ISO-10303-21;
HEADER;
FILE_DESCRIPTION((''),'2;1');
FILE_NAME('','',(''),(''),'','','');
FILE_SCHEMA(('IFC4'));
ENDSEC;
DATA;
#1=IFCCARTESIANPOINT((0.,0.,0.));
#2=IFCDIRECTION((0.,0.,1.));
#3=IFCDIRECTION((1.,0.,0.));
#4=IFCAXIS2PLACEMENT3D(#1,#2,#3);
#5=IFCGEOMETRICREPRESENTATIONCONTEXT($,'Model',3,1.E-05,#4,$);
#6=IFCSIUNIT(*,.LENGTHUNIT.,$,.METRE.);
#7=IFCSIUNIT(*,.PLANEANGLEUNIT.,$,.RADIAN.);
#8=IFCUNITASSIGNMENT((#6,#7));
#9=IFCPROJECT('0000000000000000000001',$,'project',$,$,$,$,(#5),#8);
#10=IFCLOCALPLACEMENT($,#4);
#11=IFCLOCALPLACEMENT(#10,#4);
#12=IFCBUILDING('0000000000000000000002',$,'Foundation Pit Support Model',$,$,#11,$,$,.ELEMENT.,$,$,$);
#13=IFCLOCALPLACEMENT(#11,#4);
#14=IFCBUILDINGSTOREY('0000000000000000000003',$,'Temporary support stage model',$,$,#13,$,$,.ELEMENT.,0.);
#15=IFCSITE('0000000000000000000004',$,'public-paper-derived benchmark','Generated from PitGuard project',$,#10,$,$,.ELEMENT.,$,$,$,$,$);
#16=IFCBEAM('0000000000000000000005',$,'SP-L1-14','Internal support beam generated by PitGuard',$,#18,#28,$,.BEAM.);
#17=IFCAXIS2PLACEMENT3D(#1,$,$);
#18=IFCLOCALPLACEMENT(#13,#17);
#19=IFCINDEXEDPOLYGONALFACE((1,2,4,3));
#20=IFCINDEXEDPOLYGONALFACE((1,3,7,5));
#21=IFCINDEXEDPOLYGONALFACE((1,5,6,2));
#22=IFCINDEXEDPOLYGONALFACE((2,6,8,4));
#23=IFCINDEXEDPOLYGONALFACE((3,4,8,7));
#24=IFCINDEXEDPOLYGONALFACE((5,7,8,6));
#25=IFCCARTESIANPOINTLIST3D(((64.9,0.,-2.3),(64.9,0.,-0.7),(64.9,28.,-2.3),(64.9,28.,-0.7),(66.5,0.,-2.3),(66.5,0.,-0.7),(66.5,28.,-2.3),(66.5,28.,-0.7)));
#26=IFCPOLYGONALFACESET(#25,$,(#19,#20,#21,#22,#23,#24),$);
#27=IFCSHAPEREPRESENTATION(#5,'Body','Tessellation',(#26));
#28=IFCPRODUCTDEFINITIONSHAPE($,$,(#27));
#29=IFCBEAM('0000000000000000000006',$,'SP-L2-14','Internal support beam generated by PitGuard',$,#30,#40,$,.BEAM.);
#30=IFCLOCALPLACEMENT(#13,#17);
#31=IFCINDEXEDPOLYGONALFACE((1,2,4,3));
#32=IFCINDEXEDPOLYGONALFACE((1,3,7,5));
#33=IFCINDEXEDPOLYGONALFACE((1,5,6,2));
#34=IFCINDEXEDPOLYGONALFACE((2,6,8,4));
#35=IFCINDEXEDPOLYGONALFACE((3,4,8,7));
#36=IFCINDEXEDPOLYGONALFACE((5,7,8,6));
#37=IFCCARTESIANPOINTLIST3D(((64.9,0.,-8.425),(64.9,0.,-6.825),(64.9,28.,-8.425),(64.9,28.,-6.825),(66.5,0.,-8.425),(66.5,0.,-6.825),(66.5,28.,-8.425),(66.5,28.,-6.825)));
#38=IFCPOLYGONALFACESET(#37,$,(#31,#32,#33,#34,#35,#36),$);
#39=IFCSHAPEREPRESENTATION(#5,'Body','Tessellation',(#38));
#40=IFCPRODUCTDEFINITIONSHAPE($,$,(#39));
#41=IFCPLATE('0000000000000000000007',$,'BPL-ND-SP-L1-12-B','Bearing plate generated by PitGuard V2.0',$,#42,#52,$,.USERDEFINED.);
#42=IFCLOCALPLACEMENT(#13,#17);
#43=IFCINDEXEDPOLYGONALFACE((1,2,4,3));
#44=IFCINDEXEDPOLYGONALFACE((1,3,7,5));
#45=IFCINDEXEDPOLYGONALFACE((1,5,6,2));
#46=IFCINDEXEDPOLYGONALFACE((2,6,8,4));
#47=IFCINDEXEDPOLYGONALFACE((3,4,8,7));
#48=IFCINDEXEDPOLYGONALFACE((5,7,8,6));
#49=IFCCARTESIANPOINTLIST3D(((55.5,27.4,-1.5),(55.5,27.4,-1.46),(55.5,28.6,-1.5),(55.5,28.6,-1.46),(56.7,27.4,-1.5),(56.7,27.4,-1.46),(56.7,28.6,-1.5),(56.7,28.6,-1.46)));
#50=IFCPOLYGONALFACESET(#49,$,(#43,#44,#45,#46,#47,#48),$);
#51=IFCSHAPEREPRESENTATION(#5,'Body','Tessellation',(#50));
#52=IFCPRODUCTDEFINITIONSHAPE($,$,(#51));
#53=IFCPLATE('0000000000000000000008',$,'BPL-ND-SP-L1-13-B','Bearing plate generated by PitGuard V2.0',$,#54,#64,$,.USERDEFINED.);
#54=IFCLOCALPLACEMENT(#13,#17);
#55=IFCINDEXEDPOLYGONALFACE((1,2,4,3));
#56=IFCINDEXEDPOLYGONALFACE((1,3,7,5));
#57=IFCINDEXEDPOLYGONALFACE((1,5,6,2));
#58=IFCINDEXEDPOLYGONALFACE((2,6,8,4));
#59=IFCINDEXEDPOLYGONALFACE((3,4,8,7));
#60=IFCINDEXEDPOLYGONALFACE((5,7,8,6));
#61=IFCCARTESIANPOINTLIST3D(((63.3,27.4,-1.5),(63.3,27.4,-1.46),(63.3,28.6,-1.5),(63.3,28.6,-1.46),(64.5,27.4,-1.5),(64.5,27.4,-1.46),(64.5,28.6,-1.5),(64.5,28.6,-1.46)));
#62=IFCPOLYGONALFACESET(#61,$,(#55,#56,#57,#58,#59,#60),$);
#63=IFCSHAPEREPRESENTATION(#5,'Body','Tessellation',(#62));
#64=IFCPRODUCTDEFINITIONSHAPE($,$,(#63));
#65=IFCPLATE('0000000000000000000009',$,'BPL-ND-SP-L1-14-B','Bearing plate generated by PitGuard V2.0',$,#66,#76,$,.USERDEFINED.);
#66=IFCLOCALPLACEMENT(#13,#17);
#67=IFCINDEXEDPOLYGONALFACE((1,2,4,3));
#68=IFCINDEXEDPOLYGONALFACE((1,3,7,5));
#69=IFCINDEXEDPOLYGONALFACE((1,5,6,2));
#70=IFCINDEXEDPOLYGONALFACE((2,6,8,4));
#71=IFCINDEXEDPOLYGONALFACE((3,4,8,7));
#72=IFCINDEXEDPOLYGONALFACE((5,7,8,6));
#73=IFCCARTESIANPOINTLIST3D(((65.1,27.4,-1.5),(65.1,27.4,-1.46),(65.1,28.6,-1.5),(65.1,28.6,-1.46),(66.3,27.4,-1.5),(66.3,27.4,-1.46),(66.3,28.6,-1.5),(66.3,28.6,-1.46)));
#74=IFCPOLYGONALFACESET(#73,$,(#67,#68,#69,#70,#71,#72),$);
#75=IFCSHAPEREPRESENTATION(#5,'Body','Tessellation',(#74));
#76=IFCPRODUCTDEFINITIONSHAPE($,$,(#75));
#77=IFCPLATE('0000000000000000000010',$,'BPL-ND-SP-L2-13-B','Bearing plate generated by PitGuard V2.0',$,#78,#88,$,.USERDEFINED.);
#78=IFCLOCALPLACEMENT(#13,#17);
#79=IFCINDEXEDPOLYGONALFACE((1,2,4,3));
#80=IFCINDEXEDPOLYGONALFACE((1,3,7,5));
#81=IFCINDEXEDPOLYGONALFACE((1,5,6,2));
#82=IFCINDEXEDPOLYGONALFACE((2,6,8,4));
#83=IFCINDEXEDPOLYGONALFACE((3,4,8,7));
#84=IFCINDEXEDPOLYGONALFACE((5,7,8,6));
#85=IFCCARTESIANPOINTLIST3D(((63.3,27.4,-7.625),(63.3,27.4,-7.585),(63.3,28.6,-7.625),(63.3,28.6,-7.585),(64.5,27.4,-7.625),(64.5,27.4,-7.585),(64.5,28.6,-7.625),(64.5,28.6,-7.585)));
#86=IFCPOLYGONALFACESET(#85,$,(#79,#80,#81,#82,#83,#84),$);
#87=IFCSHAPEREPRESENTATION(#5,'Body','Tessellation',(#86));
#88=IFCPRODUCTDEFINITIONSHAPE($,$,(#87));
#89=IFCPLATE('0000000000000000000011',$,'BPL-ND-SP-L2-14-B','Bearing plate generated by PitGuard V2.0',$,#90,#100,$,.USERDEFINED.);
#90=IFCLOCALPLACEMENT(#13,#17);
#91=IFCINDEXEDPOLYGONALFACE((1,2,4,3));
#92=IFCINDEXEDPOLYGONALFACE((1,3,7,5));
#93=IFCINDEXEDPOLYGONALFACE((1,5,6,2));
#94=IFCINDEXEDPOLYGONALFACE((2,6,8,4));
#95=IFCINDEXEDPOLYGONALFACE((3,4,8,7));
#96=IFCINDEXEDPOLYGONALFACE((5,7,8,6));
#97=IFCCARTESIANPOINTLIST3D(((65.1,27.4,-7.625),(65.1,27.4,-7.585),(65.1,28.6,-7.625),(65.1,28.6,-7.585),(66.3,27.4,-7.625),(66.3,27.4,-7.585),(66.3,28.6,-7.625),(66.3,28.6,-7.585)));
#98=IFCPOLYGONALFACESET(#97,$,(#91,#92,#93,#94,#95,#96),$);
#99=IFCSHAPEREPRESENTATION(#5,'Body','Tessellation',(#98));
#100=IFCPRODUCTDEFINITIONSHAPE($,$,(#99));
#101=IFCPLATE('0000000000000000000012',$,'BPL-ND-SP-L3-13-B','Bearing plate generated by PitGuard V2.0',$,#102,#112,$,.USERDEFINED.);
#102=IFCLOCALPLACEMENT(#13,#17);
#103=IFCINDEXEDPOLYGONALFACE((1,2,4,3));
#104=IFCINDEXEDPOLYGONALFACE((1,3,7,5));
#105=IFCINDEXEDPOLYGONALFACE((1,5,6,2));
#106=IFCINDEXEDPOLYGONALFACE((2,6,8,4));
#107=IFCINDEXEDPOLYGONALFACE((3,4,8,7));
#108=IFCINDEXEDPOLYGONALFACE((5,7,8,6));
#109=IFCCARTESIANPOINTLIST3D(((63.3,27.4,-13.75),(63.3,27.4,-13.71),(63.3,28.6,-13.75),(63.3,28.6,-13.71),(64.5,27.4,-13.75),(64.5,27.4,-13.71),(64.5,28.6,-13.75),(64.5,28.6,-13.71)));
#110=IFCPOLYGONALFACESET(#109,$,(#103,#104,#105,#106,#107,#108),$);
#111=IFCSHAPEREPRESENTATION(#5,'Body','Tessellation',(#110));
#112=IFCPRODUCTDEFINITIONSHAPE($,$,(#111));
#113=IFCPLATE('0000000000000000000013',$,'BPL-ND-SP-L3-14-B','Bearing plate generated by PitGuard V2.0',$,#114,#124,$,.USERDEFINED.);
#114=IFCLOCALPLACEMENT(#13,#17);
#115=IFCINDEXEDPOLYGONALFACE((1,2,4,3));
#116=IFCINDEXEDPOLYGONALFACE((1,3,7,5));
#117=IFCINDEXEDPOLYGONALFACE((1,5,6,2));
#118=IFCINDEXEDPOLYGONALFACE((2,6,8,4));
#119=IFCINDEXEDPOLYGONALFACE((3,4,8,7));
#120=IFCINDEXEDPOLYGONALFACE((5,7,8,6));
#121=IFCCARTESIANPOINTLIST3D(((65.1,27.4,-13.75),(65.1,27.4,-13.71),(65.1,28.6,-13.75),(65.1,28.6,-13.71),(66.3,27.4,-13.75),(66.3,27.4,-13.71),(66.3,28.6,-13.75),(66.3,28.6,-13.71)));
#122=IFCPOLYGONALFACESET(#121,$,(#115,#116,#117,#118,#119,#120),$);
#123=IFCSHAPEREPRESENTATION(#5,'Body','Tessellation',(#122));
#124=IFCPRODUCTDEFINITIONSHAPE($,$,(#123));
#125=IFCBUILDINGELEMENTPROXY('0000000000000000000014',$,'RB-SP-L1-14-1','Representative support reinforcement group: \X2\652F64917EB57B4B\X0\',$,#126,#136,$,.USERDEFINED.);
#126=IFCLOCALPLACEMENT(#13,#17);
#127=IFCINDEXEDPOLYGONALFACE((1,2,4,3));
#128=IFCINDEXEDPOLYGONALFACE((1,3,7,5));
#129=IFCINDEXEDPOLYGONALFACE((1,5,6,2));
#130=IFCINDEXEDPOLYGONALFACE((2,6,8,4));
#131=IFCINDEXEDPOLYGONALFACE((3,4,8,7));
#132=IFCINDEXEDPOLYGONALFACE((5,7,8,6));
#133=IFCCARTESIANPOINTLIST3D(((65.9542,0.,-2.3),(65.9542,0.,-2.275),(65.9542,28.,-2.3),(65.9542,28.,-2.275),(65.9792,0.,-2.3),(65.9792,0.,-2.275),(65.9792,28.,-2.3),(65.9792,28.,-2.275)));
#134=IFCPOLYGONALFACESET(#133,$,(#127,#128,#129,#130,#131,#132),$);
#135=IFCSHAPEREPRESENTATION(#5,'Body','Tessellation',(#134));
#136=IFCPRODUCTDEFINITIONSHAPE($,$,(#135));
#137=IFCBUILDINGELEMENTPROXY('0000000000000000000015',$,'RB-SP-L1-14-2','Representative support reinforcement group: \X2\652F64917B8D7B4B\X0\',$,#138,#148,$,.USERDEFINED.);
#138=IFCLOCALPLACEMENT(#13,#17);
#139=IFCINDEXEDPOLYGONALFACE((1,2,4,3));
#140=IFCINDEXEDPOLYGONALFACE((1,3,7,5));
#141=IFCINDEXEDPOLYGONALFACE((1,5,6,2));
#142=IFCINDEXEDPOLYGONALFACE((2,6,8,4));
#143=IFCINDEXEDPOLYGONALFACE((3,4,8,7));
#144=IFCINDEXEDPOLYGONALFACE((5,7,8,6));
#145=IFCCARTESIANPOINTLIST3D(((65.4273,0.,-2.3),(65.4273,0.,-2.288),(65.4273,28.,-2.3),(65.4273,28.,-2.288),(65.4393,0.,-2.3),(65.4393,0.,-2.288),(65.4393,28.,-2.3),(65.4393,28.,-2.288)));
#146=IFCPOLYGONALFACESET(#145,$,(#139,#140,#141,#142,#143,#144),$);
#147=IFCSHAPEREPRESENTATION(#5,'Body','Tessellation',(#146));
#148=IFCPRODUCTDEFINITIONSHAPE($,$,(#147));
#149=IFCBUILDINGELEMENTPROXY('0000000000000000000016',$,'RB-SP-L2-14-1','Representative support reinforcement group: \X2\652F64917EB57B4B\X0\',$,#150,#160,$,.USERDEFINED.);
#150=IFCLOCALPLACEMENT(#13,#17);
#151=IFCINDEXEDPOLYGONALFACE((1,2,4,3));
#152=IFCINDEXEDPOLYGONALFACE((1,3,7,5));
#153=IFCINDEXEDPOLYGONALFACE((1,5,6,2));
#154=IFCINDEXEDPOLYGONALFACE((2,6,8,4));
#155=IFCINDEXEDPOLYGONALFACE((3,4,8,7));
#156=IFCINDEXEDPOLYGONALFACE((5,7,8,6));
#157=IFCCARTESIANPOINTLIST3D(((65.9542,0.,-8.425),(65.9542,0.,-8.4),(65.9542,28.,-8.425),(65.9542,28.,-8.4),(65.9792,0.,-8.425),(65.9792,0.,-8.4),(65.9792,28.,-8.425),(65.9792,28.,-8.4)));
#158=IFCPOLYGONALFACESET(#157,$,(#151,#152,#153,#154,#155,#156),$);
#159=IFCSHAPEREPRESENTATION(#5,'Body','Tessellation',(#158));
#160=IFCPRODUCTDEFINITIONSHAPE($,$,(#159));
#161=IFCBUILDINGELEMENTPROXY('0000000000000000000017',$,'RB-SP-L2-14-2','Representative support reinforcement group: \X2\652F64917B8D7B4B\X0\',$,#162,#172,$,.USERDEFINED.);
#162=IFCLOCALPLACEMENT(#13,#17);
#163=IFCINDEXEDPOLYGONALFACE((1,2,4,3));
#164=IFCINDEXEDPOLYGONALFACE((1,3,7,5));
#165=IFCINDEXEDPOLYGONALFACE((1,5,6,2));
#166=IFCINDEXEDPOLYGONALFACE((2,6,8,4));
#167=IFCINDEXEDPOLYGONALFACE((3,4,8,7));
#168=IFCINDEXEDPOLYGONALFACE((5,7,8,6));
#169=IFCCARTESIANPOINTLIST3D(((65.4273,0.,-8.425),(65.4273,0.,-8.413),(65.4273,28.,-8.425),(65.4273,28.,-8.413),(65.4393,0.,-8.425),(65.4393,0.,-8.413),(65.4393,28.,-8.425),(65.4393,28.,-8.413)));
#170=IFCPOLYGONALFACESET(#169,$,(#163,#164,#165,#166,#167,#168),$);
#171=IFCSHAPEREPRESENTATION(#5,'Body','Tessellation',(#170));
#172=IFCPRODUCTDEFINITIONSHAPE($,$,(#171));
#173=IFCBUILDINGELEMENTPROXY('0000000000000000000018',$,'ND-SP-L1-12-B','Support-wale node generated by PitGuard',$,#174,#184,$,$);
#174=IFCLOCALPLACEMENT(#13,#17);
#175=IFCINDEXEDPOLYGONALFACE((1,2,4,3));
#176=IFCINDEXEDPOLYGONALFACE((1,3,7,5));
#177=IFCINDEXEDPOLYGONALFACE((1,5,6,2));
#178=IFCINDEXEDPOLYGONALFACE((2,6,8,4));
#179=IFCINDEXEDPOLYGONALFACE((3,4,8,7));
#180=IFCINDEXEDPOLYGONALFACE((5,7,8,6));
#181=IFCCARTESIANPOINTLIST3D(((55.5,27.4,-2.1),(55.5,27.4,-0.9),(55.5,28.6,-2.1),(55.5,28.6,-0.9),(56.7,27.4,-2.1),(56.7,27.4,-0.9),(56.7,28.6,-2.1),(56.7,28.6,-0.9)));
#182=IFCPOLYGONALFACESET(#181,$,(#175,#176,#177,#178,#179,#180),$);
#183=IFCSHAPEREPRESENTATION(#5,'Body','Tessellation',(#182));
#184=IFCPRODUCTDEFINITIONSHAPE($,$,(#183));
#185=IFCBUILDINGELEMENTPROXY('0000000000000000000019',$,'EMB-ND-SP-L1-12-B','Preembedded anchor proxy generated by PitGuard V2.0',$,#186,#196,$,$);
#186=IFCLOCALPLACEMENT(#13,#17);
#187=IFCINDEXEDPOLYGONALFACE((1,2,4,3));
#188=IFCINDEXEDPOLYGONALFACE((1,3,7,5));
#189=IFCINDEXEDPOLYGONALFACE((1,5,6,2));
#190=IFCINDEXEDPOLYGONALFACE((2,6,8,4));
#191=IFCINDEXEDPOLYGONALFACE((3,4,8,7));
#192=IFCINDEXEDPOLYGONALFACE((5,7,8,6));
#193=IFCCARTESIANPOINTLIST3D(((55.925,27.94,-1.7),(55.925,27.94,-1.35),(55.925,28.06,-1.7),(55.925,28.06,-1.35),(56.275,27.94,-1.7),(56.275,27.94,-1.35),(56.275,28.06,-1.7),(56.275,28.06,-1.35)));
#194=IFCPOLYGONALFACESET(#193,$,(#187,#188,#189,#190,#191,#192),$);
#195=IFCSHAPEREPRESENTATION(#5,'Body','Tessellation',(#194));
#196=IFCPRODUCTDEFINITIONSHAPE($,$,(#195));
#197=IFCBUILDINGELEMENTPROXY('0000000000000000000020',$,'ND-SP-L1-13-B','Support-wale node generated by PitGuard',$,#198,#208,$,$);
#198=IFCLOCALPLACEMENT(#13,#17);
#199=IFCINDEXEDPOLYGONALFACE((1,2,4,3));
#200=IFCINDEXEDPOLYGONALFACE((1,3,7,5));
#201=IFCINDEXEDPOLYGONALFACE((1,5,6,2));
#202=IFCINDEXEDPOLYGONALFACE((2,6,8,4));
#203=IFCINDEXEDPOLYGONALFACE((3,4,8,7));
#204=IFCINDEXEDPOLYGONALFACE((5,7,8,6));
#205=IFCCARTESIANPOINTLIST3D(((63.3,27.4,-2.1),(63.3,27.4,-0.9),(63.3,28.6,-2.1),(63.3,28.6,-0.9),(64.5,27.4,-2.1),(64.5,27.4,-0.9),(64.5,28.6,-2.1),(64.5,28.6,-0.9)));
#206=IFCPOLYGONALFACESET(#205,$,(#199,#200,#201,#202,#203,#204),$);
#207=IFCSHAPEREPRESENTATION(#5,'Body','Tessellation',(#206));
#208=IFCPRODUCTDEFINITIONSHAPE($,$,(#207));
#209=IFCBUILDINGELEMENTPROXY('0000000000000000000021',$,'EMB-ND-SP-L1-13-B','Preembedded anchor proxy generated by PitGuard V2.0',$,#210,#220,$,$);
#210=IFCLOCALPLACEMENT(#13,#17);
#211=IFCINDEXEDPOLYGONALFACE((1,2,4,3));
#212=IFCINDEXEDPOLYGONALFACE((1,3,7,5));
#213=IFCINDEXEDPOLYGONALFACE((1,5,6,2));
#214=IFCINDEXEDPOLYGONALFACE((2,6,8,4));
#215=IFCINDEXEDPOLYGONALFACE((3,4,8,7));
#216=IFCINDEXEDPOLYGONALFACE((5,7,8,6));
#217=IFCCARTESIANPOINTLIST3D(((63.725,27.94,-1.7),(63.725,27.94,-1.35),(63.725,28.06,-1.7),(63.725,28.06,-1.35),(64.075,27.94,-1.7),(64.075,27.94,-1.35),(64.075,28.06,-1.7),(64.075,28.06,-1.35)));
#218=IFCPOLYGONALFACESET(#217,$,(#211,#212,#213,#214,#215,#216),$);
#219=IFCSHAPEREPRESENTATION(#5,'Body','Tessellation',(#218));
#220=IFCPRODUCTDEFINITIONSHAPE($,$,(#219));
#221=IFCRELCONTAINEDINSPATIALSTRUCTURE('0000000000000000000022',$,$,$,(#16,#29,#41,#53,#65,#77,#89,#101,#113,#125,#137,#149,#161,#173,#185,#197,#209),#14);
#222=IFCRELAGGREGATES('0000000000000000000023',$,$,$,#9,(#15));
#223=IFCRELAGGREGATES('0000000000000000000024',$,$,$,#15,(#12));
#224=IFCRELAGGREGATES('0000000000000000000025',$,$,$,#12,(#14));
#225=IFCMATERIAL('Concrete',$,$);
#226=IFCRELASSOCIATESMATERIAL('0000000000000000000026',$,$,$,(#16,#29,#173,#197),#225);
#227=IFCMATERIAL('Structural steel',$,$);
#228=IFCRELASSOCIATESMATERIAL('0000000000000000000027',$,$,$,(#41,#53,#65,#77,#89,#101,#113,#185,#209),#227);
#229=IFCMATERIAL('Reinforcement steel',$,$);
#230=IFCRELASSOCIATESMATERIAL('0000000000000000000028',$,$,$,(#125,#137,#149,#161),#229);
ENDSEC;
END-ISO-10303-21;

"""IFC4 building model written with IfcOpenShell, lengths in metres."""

from ifc_helpers import new_model, si_unit, frame, origin_with_axes, origin_2d, place, context, project, spatial, rectangle, extrude, material, element, save


model = new_model("IFC4")

# Units and contexts
model_context = context("Model", 3, precision=1e-05, world=origin_with_axes())
ifc_project = project(units=[si_unit("LENGTHUNIT", "METRE"), si_unit("PLANEANGLEUNIT", "RADIAN")], contexts=[model_context])

# Site, building, storey
site_placement = place(None, origin_with_axes())
site = spatial("IfcSite", under=ifc_project, at=site_placement, Name="public-paper-derived benchmark", Description="Generated from PitGuard project", CompositionType="ELEMENT")
building_placement = place(site_placement, origin_with_axes())
building = spatial("IfcBuilding", under=site, at=building_placement, Name="Foundation Pit Support Model", CompositionType="ELEMENT")
storey_placement = place(building_placement, origin_with_axes())
storey = spatial("IfcBuildingStorey", under=building, at=storey_placement, Name="Temporary support stage model", CompositionType="ELEMENT", Elevation=0.0)

# Beams
ifc_material_1 = material(Name="Concrete")
for number, where, z_axis, x_axis, name in (
    (1, (65.7, 14.0, -2.3), (0.0, 0.0, 1.0), (0.0, 1.0, 0.0), "SP-L1-14"),
    (2, (65.7, 14.0, -8.425), (0.0, 0.0, 1.0), (0.0, 1.0, 0.0), "SP-L2-14"),
):
    element("IfcBeam", number, at=place(storey_placement, frame(where, z_axis=z_axis, x_axis=x_axis)), inside=storey, material=ifc_material_1, Name=name, Description="Internal support beam generated by PitGuard", PredefinedType="BEAM", context=model_context, shape_type="SweptSolid", body=[
        extrude(rectangle(XDim=28.0, YDim=1.6, at=origin_2d()), origin_with_axes(), (0.0, 0.0, 1.0), 1.6),
    ])

# Plates
ifc_material_2 = material(Name="Structural steel")
for number, where, z_axis, x_axis, name in (
    (3, (56.1, 28.0, -1.5), (0.0, 0.0, 1.0), (1.0, 0.0, 0.0), "BPL-ND-SP-L1-12-B"),
    (4, (63.9, 28.0, -1.5), (0.0, 0.0, 1.0), (1.0, 0.0, 0.0), "BPL-ND-SP-L1-13-B"),
    (5, (65.7, 28.0, -1.5), (0.0, 0.0, 1.0), (1.0, 0.0, 0.0), "BPL-ND-SP-L1-14-B"),
    (6, (63.9, 28.0, -7.625), (0.0, 0.0, 1.0), (1.0, 0.0, 0.0), "BPL-ND-SP-L2-13-B"),
    (7, (65.7, 28.0, -7.625), (0.0, 0.0, 1.0), (1.0, 0.0, 0.0), "BPL-ND-SP-L2-14-B"),
    (8, (63.9, 28.0, -13.75), (0.0, 0.0, 1.0), (1.0, 0.0, 0.0), "BPL-ND-SP-L3-13-B"),
    (9, (65.7, 28.0, -13.75), (0.0, 0.0, 1.0), (1.0, 0.0, 0.0), "BPL-ND-SP-L3-14-B"),
):
    element("IfcPlate", number, at=place(storey_placement, frame(where, z_axis=z_axis, x_axis=x_axis)), inside=storey, material=ifc_material_2, Name=name, Description="Bearing plate generated by PitGuard V2.0", PredefinedType="USERDEFINED", context=model_context, shape_type="SweptSolid", body=[
        extrude(rectangle(XDim=1.2, YDim=1.2, at=origin_2d()), origin_with_axes(), (0.0, 0.0, 1.0), 0.04),
    ])

# Building element proxies
ifc_material_3 = material(Name="Reinforcement steel")
proxy_1_placement = place(storey_placement, frame((65.9667, 14.0, -2.3), z_axis=(0.0, 0.0, 1.0), x_axis=(0.0, 1.0, 0.0)))
element("IfcBuildingElementProxy", 10, at=proxy_1_placement, inside=storey, material=ifc_material_3, Name="RB-SP-L1-14-1", Description="Representative support reinforcement group: 支撑纵筋", PredefinedType="USERDEFINED", context=model_context, shape_type="SweptSolid", body=[
    extrude(rectangle(XDim=28.0, YDim=0.025, at=origin_2d()), origin_with_axes(), (0.0, 0.0, 1.0), 0.025),
])
proxy_2_placement = place(storey_placement, frame((65.4333, 14.0, -2.3), z_axis=(0.0, 0.0, 1.0), x_axis=(0.0, 1.0, 0.0)))
element("IfcBuildingElementProxy", 11, at=proxy_2_placement, inside=storey, material=ifc_material_3, Name="RB-SP-L1-14-2", Description="Representative support reinforcement group: 支撑箍筋", PredefinedType="USERDEFINED", context=model_context, shape_type="SweptSolid", body=[
    extrude(rectangle(XDim=28.0, YDim=0.012, at=origin_2d()), origin_with_axes(), (0.0, 0.0, 1.0), 0.012),
])
proxy_3_placement = place(storey_placement, frame((65.9667, 14.0, -8.425), z_axis=(0.0, 0.0, 1.0), x_axis=(0.0, 1.0, 0.0)))
element("IfcBuildingElementProxy", 12, at=proxy_3_placement, inside=storey, material=ifc_material_3, Name="RB-SP-L2-14-1", Description="Representative support reinforcement group: 支撑纵筋", PredefinedType="USERDEFINED", context=model_context, shape_type="SweptSolid", body=[
    extrude(rectangle(XDim=28.0, YDim=0.025, at=origin_2d()), origin_with_axes(), (0.0, 0.0, 1.0), 0.025),
])
proxy_4_placement = place(storey_placement, frame((65.4333, 14.0, -8.425), z_axis=(0.0, 0.0, 1.0), x_axis=(0.0, 1.0, 0.0)))
element("IfcBuildingElementProxy", 13, at=proxy_4_placement, inside=storey, material=ifc_material_3, Name="RB-SP-L2-14-2", Description="Representative support reinforcement group: 支撑箍筋", PredefinedType="USERDEFINED", context=model_context, shape_type="SweptSolid", body=[
    extrude(rectangle(XDim=28.0, YDim=0.012, at=origin_2d()), origin_with_axes(), (0.0, 0.0, 1.0), 0.012),
])
proxy_5_placement = place(storey_placement, frame((56.1, 28.0, -2.1), z_axis=(0.0, 0.0, 1.0), x_axis=(1.0, 0.0, 0.0)))
element("IfcBuildingElementProxy", 14, at=proxy_5_placement, inside=storey, material=ifc_material_1, Name="ND-SP-L1-12-B", Description="Support-wale node generated by PitGuard", context=model_context, shape_type="SweptSolid", body=[
    extrude(rectangle(XDim=1.2, YDim=1.2, at=origin_2d()), origin_with_axes(), (0.0, 0.0, 1.0), 1.2),
])
proxy_6_placement = place(storey_placement, frame((56.1, 28.0, -1.7), z_axis=(0.0, 0.0, 1.0), x_axis=(1.0, 0.0, 0.0)))
element("IfcBuildingElementProxy", 15, at=proxy_6_placement, inside=storey, material=ifc_material_2, Name="EMB-ND-SP-L1-12-B", Description="Preembedded anchor proxy generated by PitGuard V2.0", context=model_context, shape_type="SweptSolid", body=[
    extrude(rectangle(XDim=0.35, YDim=0.12, at=origin_2d()), origin_with_axes(), (0.0, 0.0, 1.0), 0.35),
])
proxy_7_placement = place(storey_placement, frame((63.9, 28.0, -2.1), z_axis=(0.0, 0.0, 1.0), x_axis=(1.0, 0.0, 0.0)))
element("IfcBuildingElementProxy", 16, at=proxy_7_placement, inside=storey, material=ifc_material_1, Name="ND-SP-L1-13-B", Description="Support-wale node generated by PitGuard", context=model_context, shape_type="SweptSolid", body=[
    extrude(rectangle(XDim=1.2, YDim=1.2, at=origin_2d()), origin_with_axes(), (0.0, 0.0, 1.0), 1.2),
])
proxy_8_placement = place(storey_placement, frame((63.9, 28.0, -1.7), z_axis=(0.0, 0.0, 1.0), x_axis=(1.0, 0.0, 0.0)))
element("IfcBuildingElementProxy", 17, at=proxy_8_placement, inside=storey, material=ifc_material_2, Name="EMB-ND-SP-L1-13-B", Description="Preembedded anchor proxy generated by PitGuard V2.0", context=model_context, shape_type="SweptSolid", body=[
    extrude(rectangle(XDim=0.35, YDim=0.12, at=origin_2d()), origin_with_axes(), (0.0, 0.0, 1.0), 0.35),
])

save(model, "model.ifc")
